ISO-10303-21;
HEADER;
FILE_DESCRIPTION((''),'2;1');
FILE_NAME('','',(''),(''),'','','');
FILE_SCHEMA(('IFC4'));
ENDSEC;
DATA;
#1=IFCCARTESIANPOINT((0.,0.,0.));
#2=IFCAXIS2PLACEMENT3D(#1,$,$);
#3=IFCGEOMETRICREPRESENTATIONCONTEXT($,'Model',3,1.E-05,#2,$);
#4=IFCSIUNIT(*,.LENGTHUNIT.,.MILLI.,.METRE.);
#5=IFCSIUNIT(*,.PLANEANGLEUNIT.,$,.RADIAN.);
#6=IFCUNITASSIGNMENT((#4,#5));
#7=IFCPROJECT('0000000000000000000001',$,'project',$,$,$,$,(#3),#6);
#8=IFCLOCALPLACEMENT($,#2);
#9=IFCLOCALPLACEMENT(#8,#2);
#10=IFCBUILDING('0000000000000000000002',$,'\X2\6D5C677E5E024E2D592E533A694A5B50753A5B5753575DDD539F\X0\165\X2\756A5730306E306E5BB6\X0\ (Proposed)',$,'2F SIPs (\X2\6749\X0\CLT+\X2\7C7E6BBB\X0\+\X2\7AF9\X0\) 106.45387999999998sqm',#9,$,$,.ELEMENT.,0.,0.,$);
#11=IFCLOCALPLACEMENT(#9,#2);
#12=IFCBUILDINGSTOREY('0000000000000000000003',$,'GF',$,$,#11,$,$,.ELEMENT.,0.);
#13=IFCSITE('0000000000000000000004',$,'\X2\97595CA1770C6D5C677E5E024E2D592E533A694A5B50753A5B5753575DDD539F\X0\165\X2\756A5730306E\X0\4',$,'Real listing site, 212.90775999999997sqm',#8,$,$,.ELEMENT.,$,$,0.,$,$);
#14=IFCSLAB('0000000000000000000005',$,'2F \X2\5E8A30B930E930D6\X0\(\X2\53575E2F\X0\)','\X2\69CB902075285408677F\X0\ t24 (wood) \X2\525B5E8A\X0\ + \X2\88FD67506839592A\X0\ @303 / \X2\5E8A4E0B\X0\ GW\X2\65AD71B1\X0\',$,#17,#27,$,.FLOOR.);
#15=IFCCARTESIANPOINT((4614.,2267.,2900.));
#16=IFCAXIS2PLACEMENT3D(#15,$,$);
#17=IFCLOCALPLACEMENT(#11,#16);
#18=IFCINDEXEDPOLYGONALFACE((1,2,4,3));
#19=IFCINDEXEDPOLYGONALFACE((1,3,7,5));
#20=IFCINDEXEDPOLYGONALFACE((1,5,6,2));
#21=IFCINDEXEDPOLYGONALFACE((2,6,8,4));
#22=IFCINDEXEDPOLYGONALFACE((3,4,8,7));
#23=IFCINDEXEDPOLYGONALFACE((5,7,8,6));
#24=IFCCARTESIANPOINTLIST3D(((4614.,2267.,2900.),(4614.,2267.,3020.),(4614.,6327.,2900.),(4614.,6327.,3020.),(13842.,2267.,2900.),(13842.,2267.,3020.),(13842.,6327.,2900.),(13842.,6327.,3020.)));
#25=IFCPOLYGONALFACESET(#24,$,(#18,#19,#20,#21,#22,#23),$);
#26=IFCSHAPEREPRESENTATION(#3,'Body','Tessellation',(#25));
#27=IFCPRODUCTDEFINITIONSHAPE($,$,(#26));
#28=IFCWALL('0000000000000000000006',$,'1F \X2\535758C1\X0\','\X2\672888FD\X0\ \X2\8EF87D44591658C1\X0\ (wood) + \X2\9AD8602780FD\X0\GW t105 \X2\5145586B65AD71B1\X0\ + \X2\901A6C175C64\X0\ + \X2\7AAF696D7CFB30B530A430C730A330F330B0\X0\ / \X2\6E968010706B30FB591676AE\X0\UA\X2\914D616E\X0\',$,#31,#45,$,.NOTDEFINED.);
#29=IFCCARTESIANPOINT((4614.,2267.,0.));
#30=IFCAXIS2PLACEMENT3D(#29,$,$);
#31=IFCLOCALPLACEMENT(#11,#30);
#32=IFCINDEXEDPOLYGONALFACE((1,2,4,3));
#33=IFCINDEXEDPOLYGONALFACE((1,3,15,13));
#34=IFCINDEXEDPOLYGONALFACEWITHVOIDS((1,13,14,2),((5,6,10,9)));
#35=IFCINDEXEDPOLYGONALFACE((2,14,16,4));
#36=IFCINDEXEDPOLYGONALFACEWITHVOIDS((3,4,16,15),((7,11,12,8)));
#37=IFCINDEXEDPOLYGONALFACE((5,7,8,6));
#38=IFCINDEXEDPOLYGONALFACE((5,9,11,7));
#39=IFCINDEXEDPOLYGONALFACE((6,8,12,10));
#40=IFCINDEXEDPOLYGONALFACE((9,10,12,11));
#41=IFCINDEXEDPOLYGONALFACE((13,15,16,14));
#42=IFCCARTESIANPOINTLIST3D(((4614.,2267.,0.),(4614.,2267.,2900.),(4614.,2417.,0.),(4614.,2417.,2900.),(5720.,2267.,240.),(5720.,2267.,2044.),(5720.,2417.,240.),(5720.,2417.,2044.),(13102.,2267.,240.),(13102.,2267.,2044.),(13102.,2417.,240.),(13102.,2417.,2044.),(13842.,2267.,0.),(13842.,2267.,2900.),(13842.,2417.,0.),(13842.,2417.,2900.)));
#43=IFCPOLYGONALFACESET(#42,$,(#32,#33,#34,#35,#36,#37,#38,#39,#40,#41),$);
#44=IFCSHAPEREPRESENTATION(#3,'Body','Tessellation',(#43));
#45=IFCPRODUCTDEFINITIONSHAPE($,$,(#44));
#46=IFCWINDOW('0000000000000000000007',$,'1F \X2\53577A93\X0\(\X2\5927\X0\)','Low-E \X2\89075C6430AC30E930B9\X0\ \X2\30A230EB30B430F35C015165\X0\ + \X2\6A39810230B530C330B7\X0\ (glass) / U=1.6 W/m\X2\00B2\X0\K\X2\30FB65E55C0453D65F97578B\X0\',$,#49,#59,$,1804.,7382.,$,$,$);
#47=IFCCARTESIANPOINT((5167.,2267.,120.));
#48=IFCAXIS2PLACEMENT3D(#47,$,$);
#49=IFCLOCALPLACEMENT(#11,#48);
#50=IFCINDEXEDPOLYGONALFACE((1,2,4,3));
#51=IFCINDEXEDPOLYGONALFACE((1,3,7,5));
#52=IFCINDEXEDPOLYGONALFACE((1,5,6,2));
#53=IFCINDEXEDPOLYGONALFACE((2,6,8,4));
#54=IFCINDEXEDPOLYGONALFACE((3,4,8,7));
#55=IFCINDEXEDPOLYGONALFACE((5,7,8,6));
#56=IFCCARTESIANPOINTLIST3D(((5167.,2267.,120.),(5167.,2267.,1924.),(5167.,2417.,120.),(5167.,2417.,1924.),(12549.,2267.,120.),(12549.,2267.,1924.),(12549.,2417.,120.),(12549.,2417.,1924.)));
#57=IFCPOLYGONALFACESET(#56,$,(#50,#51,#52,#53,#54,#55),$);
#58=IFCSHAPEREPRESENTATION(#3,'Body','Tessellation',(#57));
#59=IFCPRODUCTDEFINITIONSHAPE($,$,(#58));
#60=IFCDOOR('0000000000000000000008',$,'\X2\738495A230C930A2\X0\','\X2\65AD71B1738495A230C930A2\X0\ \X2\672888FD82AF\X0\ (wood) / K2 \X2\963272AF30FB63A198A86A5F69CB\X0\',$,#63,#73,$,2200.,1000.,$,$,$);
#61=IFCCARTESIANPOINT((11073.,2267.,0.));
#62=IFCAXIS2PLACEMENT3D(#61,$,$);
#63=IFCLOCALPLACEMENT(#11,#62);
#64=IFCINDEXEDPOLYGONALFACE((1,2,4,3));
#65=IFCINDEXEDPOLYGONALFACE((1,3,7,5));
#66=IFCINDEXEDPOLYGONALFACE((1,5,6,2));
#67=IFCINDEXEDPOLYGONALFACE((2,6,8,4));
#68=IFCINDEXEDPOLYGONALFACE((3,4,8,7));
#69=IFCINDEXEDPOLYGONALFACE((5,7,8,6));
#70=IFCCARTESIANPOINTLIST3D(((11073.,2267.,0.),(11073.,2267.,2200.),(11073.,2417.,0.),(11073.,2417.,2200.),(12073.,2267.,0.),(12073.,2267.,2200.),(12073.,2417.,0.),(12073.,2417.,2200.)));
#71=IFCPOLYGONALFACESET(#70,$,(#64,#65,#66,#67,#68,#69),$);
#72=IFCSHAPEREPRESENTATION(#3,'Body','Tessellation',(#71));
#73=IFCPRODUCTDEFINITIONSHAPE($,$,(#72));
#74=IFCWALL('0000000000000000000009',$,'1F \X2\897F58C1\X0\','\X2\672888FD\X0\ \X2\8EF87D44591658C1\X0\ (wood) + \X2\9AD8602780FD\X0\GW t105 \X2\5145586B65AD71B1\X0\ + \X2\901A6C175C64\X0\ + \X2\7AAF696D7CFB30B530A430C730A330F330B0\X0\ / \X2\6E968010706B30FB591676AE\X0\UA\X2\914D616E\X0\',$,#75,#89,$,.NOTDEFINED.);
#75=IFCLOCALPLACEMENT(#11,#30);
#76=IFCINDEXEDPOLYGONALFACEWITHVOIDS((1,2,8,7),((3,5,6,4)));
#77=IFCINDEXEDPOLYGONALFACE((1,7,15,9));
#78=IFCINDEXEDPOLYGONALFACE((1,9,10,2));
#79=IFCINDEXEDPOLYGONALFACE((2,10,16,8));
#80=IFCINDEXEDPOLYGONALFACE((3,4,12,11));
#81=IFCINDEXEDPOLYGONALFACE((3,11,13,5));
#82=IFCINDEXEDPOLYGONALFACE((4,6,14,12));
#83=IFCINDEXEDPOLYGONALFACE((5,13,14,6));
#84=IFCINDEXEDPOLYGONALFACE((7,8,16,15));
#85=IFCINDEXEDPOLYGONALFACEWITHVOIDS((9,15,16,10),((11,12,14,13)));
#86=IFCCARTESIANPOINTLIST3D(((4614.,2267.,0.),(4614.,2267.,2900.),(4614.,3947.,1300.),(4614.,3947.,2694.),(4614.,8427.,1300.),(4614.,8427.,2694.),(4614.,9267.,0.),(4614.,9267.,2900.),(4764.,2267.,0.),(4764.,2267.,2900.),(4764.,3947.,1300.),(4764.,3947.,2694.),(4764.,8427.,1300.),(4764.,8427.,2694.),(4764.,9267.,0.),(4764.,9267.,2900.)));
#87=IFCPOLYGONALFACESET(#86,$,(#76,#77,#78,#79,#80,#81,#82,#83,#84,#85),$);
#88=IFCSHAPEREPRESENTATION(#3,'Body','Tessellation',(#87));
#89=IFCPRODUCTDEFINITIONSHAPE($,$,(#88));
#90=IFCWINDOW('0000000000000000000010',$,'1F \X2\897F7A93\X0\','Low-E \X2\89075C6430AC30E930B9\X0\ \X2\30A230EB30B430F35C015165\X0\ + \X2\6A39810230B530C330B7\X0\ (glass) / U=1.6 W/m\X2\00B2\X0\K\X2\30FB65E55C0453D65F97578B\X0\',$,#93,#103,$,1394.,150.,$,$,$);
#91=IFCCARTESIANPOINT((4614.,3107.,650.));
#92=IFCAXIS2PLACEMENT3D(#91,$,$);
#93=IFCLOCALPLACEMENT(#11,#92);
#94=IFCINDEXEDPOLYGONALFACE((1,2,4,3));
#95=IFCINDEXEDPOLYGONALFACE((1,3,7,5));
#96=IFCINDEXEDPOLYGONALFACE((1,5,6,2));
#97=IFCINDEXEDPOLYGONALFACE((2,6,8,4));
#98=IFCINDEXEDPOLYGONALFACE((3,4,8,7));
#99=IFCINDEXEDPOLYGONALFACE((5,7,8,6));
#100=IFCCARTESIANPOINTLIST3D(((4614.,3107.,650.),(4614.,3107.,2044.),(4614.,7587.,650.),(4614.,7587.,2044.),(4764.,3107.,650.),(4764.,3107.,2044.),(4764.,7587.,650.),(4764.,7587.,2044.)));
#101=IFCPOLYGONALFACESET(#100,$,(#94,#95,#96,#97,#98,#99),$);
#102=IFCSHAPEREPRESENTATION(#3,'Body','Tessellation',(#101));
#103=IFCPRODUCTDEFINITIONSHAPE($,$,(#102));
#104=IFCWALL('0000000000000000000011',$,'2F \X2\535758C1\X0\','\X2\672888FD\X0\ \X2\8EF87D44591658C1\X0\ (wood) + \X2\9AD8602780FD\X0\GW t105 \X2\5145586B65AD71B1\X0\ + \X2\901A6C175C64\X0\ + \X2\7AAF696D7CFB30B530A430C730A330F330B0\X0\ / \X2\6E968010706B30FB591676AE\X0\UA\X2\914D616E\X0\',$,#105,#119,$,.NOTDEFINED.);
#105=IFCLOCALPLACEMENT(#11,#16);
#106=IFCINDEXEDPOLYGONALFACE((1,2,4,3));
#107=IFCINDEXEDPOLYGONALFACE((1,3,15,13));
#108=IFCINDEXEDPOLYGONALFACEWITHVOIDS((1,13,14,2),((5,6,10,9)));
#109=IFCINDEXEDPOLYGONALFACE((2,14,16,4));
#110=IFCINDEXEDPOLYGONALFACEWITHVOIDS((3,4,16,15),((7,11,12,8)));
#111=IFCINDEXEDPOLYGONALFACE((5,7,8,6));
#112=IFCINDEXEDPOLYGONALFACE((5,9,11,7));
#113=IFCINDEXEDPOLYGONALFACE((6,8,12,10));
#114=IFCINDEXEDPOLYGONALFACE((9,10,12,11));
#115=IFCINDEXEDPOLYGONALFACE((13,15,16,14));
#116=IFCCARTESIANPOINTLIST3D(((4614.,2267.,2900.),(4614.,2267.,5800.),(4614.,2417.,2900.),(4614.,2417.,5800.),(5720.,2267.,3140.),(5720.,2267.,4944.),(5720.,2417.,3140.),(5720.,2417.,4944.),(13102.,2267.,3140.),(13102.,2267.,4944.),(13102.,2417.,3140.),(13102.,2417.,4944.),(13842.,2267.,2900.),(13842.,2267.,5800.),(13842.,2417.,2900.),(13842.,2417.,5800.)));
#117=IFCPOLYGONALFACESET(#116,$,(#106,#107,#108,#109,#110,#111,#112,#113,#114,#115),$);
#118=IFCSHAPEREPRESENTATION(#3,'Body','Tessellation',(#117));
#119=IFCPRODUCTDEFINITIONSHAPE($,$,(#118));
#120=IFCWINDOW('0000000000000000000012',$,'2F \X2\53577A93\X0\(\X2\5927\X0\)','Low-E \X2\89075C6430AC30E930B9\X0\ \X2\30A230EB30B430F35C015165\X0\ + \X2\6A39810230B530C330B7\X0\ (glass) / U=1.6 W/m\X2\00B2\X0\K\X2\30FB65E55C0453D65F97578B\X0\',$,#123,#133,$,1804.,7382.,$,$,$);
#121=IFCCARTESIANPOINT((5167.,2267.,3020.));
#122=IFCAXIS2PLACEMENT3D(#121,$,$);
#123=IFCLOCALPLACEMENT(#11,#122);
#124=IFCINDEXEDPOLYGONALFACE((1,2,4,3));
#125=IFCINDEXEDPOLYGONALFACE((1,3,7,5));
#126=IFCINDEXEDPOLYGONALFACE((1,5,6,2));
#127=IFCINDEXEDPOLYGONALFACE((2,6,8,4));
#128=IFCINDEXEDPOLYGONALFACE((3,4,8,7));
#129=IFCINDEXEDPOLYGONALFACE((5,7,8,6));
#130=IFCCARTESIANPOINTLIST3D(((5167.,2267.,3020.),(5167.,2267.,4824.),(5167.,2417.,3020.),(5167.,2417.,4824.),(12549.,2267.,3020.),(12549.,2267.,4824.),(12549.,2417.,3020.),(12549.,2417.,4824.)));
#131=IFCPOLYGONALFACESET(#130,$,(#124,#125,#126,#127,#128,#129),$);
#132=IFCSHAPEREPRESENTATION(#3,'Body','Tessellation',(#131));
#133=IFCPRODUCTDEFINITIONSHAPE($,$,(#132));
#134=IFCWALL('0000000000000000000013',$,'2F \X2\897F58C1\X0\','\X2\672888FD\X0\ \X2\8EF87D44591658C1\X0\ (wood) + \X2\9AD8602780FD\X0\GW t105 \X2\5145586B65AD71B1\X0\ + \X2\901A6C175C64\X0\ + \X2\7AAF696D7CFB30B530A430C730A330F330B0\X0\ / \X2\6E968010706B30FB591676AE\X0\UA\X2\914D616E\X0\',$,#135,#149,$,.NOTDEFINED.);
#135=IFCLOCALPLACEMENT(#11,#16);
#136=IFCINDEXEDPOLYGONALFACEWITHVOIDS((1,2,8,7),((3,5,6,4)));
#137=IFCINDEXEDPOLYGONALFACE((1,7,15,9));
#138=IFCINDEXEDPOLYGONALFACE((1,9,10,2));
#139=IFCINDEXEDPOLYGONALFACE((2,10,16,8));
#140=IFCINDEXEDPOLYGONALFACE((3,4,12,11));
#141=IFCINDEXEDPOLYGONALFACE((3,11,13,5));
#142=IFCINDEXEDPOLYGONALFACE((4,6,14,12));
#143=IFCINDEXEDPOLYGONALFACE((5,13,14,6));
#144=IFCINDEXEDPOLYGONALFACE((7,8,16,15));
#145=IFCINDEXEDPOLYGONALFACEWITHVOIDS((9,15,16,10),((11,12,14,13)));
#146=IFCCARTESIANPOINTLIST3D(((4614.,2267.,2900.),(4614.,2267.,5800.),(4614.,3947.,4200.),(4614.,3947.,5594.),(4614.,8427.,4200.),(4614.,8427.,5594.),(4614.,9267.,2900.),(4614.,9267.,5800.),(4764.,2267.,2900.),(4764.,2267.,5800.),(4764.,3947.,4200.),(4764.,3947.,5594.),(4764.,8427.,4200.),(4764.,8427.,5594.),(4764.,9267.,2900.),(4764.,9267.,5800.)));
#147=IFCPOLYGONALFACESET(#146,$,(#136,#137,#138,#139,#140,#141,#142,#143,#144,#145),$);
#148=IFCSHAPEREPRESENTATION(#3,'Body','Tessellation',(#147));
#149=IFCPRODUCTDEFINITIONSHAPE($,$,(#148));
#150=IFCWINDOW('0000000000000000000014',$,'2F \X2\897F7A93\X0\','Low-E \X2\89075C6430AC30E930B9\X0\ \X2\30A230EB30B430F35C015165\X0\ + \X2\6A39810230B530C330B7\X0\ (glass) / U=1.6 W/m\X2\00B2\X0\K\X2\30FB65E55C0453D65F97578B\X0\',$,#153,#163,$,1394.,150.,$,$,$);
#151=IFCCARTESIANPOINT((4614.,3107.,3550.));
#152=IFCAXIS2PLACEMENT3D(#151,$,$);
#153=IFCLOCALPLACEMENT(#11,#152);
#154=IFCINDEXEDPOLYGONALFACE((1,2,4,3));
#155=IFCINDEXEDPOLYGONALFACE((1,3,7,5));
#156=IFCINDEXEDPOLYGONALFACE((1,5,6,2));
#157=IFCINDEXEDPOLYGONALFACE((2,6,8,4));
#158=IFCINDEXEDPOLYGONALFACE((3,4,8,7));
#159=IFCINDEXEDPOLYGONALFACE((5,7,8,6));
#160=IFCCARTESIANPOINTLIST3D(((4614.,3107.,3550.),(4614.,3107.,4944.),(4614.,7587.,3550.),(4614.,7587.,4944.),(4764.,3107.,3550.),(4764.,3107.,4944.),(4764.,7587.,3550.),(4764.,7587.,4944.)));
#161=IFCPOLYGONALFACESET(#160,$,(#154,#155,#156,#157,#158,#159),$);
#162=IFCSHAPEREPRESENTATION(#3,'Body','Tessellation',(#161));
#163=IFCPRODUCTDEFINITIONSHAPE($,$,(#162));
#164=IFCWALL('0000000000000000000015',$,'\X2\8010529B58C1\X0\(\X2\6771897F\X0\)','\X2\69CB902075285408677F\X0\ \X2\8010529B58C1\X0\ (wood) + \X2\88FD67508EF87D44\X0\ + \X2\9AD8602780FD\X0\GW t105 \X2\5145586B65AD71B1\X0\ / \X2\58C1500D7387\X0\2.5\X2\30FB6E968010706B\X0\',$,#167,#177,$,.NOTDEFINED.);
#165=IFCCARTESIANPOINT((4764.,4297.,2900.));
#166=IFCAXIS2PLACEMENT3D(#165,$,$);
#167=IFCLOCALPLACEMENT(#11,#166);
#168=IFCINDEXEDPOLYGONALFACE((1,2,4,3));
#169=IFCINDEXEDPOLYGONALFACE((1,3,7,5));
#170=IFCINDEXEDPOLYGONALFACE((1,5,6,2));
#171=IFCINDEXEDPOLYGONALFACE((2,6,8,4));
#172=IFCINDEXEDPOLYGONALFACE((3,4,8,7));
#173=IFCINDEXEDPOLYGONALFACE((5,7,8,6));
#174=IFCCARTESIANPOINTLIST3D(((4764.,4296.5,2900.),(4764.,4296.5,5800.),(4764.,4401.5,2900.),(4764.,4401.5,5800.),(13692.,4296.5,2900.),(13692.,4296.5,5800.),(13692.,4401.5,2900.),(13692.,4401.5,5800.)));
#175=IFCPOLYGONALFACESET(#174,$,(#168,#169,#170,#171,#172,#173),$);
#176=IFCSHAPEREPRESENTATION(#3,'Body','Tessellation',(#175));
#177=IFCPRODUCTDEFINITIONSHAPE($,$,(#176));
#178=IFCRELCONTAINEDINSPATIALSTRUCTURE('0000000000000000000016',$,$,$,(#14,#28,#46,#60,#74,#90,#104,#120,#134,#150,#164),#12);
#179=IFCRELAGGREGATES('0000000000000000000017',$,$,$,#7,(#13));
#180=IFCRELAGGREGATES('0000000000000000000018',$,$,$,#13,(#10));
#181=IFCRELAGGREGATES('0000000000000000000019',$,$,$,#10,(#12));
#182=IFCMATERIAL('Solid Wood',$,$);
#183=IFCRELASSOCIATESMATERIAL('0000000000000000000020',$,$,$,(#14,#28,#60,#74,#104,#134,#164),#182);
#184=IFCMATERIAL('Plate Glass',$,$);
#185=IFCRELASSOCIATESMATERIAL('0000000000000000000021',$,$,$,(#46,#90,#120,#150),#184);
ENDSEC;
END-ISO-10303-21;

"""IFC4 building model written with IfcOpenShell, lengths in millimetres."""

from ifc_helpers import new_model, si_unit, frame, frame_2d, origin, place, context, project, spatial, rectangle, extrude, material, element, fill, save


model = new_model("IFC4")

# Units and contexts
model_context = context("Model", 3, precision=1e-05, world=origin())
ifc_project = project(units=[si_unit("LENGTHUNIT", "METRE", prefix="MILLI"), si_unit("PLANEANGLEUNIT", "RADIAN")], contexts=[model_context])

# Site, building, storey
site_placement = place(None, origin())
site = spatial("IfcSite", under=ifc_project, at=site_placement, Name="静岡県浜松市中央区楊子町字南川原165番地の4", ObjectType="Real listing site, 212.90775999999997sqm", CompositionType="ELEMENT", RefElevation=0.0)
building_placement = place(site_placement, origin())
building = spatial("IfcBuilding", under=site, at=building_placement, Name="浜松市中央区楊子町字南川原165番地のの家 (Proposed)", ObjectType="2F SIPs (杉CLT+籾殻+竹) 106.45387999999998sqm", CompositionType="ELEMENT", ElevationOfRefHeight=0.0, ElevationOfTerrain=0.0)
storey_placement = place(building_placement, origin())
storey = spatial("IfcBuildingStorey", under=building, at=storey_placement, Name="GF", CompositionType="ELEMENT", Elevation=0.0)

# Slab
ifc_material_1 = material(Name="Solid Wood")
slab_1_placement = place(storey_placement, frame((4614.0, 2267.0, 2900.0)))
element("IfcSlab", 1, at=slab_1_placement, inside=storey, material=ifc_material_1, Name="2F 床スラブ(南帯)", Description="構造用合板 t24 (wood) 剛床 + 製材根太 @303 / 床下 GW断熱", PredefinedType="FLOOR", context=model_context, shape_type="SweptSolid", body=[
    extrude(rectangle(XDim=9228.0, YDim=4060.0, at=frame_2d((4614.0, 2030.0))), frame((4614.0, 2267.0, 2900.0)), (0.0, 0.0, 1.0), 120.0),
])

# Wall, openings, window, door
wall_1_placement = place(storey_placement, frame((4614.0, 2267.0, 0.0)))
wall_1 = element("IfcWall", 2, at=wall_1_placement, inside=storey, material=ifc_material_1, Name="1F 南壁", Description="木製 軸組外壁 (wood) + 高性能GW t105 充填断熱 + 通気層 + 窯業系サイディング / 準耐火・外皮UA配慮", PredefinedType="NOTDEFINED", context=model_context, shape_type="SweptSolid", body=[
    extrude(rectangle(XDim=9228.0, YDim=150.0, at=frame_2d((4614.0, 75.0))), frame((4614.0, 2267.0, 0.0)), (0.0, 0.0, 1.0), 2900.0),
])
opening_1_placement = place(storey_placement, frame((5167.0, 2267.0, 120.0)))
opening_1 = element("IfcOpeningElement", 3, at=opening_1_placement, cuts=wall_1, PredefinedType="NOTDEFINED", context=model_context, shape_type="SweptSolid", body=[
    extrude(rectangle(XDim=7382.0, YDim=150.0, at=frame_2d((3691.0, 75.0))), frame((5167.0, 2267.0, 120.0)), (0.0, 0.0, 1.0), 1804.0),
])
opening_2_placement = place(storey_placement, frame((11073.0, 2267.0, 0.0)))
opening_2 = element("IfcOpeningElement", 4, at=opening_2_placement, cuts=wall_1, PredefinedType="NOTDEFINED", context=model_context, shape_type="SweptSolid", body=[
    extrude(rectangle(XDim=1000.0, YDim=150.0, at=frame_2d((500.0, 75.0))), frame((11073.0, 2267.0, 0.0)), (0.0, 0.0, 1.0), 2200.0),
])
ifc_material_2 = material(Name="Plate Glass")
window_1_placement = place(storey_placement, frame((5167.0, 2267.0, 120.0)))
window_1 = element("IfcWindow", 5, at=window_1_placement, inside=storey, material=ifc_material_2, Name="1F 南窓(大)", Description="Low-E 複層ガラス アルゴン封入 + 樹脂サッシ (glass) / U=1.6 W/m²K・日射取得型", OverallHeight=1804.0, OverallWidth=7382.0, context=model_context, shape_type="SweptSolid", body=[
    extrude(rectangle(XDim=7382.0, YDim=150.0, at=frame_2d((3691.0, 75.0))), frame((5167.0, 2267.0, 120.0)), (0.0, 0.0, 1.0), 1804.0),
])
fill(opening_1, window_1)
door_placement = place(storey_placement, frame((11073.0, 2267.0, 0.0)))
door = element("IfcDoor", 6, at=door_placement, inside=storey, material=ifc_material_1, Name="玄関ドア", Description="断熱玄関ドア 木製芯 (wood) / K2 防犯・採風機構", OverallHeight=2200.0, OverallWidth=1000.0, context=model_context, shape_type="SweptSolid", body=[
    extrude(rectangle(XDim=1000.0, YDim=150.0, at=frame_2d((500.0, 75.0))), frame((11073.0, 2267.0, 0.0)), (0.0, 0.0, 1.0), 2200.0),
])
fill(opening_2, door)

# Wall, opening, window
wall_2_placement = place(storey_placement, frame((4614.0, 2267.0, 0.0)))
wall_2 = element("IfcWall", 7, at=wall_2_placement, inside=storey, material=ifc_material_1, Name="1F 西壁", Description="木製 軸組外壁 (wood) + 高性能GW t105 充填断熱 + 通気層 + 窯業系サイディング / 準耐火・外皮UA配慮", PredefinedType="NOTDEFINED", context=model_context, shape_type="SweptSolid", body=[
    extrude(rectangle(XDim=150.0, YDim=7000.0, at=frame_2d((75.0, 3500.0))), frame((4614.0, 2267.0, 0.0)), (0.0, 0.0, 1.0), 2900.0),
])
opening_3_placement = place(storey_placement, frame((4614.0, 3107.0, 650.0)))
opening_3 = element("IfcOpeningElement", 8, at=opening_3_placement, cuts=wall_2, PredefinedType="NOTDEFINED", context=model_context, shape_type="SweptSolid", body=[
    extrude(rectangle(XDim=150.0, YDim=4480.0, at=frame_2d((75.0, 2240.0))), frame((4614.0, 3107.0, 650.0)), (0.0, 0.0, 1.0), 1394.0),
])
window_2_placement = place(storey_placement, frame((4614.0, 3107.0, 650.0)))
window_2 = element("IfcWindow", 9, at=window_2_placement, inside=storey, material=ifc_material_2, Name="1F 西窓", Description="Low-E 複層ガラス アルゴン封入 + 樹脂サッシ (glass) / U=1.6 W/m²K・日射取得型", OverallHeight=1394.0, OverallWidth=150.0, context=model_context, shape_type="SweptSolid", body=[
    extrude(rectangle(XDim=150.0, YDim=4480.0, at=frame_2d((75.0, 2240.0))), frame((4614.0, 3107.0, 650.0)), (0.0, 0.0, 1.0), 1394.0),
])
fill(opening_3, window_2)

# Walls, openings, windows
wall_3_placement = place(storey_placement, frame((4614.0, 2267.0, 2900.0)))
wall_3 = element("IfcWall", 10, at=wall_3_placement, inside=storey, material=ifc_material_1, Name="2F 南壁", Description="木製 軸組外壁 (wood) + 高性能GW t105 充填断熱 + 通気層 + 窯業系サイディング / 準耐火・外皮UA配慮", PredefinedType="NOTDEFINED", context=model_context, shape_type="SweptSolid", body=[
    extrude(rectangle(XDim=9228.0, YDim=150.0, at=frame_2d((4614.0, 75.0))), frame((4614.0, 2267.0, 2900.0)), (0.0, 0.0, 1.0), 2900.0),
])
opening_4_placement = place(storey_placement, frame((5167.0, 2267.0, 3020.0)))
opening_4 = element("IfcOpeningElement", 11, at=opening_4_placement, cuts=wall_3, PredefinedType="NOTDEFINED", context=model_context, shape_type="SweptSolid", body=[
    extrude(rectangle(XDim=7382.0, YDim=150.0, at=frame_2d((3691.0, 75.0))), frame((5167.0, 2267.0, 3020.0)), (0.0, 0.0, 1.0), 1804.0),
])
window_3_placement = place(storey_placement, frame((5167.0, 2267.0, 3020.0)))
window_3 = element("IfcWindow", 12, at=window_3_placement, inside=storey, material=ifc_material_2, Name="2F 南窓(大)", Description="Low-E 複層ガラス アルゴン封入 + 樹脂サッシ (glass) / U=1.6 W/m²K・日射取得型", OverallHeight=1804.0, OverallWidth=7382.0, context=model_context, shape_type="SweptSolid", body=[
    extrude(rectangle(XDim=7382.0, YDim=150.0, at=frame_2d((3691.0, 75.0))), frame((5167.0, 2267.0, 3020.0)), (0.0, 0.0, 1.0), 1804.0),
])
fill(opening_4, window_3)
wall_4_placement = place(storey_placement, frame((4614.0, 2267.0, 2900.0)))
wall_4 = element("IfcWall", 13, at=wall_4_placement, inside=storey, material=ifc_material_1, Name="2F 西壁", Description="木製 軸組外壁 (wood) + 高性能GW t105 充填断熱 + 通気層 + 窯業系サイディング / 準耐火・外皮UA配慮", PredefinedType="NOTDEFINED", context=model_context, shape_type="SweptSolid", body=[
    extrude(rectangle(XDim=150.0, YDim=7000.0, at=frame_2d((75.0, 3500.0))), frame((4614.0, 2267.0, 2900.0)), (0.0, 0.0, 1.0), 2900.0),
])
opening_5_placement = place(storey_placement, frame((4614.0, 3107.0, 3550.0)))
opening_5 = element("IfcOpeningElement", 14, at=opening_5_placement, cuts=wall_4, PredefinedType="NOTDEFINED", context=model_context, shape_type="SweptSolid", body=[
    extrude(rectangle(XDim=150.0, YDim=4480.0, at=frame_2d((75.0, 2240.0))), frame((4614.0, 3107.0, 3550.0)), (0.0, 0.0, 1.0), 1394.0),
])
window_4_placement = place(storey_placement, frame((4614.0, 3107.0, 3550.0)))
window_4 = element("IfcWindow", 15, at=window_4_placement, inside=storey, material=ifc_material_2, Name="2F 西窓", Description="Low-E 複層ガラス アルゴン封入 + 樹脂サッシ (glass) / U=1.6 W/m²K・日射取得型", OverallHeight=1394.0, OverallWidth=150.0, context=model_context, shape_type="SweptSolid", body=[
    extrude(rectangle(XDim=150.0, YDim=4480.0, at=frame_2d((75.0, 2240.0))), frame((4614.0, 3107.0, 3550.0)), (0.0, 0.0, 1.0), 1394.0),
])
fill(opening_5, window_4)

# Wall
wall_5_placement = place(storey_placement, frame((4764.0, 4297.0, 2900.0)))
element("IfcWall", 16, at=wall_5_placement, inside=storey, material=ifc_material_1, Name="耐力壁(東西)", Description="構造用合板 耐力壁 (wood) + 製材軸組 + 高性能GW t105 充填断熱 / 壁倍率2.5・準耐火", PredefinedType="NOTDEFINED", context=model_context, shape_type="SweptSolid", body=[
    extrude(rectangle(XDim=8928.0, YDim=105.0, at=frame_2d((4464.0, 52.0))), frame((4764.0, 4297.0, 2900.0)), (0.0, 0.0, 1.0), 2900.0),
])

save(model, "model.ifc")
